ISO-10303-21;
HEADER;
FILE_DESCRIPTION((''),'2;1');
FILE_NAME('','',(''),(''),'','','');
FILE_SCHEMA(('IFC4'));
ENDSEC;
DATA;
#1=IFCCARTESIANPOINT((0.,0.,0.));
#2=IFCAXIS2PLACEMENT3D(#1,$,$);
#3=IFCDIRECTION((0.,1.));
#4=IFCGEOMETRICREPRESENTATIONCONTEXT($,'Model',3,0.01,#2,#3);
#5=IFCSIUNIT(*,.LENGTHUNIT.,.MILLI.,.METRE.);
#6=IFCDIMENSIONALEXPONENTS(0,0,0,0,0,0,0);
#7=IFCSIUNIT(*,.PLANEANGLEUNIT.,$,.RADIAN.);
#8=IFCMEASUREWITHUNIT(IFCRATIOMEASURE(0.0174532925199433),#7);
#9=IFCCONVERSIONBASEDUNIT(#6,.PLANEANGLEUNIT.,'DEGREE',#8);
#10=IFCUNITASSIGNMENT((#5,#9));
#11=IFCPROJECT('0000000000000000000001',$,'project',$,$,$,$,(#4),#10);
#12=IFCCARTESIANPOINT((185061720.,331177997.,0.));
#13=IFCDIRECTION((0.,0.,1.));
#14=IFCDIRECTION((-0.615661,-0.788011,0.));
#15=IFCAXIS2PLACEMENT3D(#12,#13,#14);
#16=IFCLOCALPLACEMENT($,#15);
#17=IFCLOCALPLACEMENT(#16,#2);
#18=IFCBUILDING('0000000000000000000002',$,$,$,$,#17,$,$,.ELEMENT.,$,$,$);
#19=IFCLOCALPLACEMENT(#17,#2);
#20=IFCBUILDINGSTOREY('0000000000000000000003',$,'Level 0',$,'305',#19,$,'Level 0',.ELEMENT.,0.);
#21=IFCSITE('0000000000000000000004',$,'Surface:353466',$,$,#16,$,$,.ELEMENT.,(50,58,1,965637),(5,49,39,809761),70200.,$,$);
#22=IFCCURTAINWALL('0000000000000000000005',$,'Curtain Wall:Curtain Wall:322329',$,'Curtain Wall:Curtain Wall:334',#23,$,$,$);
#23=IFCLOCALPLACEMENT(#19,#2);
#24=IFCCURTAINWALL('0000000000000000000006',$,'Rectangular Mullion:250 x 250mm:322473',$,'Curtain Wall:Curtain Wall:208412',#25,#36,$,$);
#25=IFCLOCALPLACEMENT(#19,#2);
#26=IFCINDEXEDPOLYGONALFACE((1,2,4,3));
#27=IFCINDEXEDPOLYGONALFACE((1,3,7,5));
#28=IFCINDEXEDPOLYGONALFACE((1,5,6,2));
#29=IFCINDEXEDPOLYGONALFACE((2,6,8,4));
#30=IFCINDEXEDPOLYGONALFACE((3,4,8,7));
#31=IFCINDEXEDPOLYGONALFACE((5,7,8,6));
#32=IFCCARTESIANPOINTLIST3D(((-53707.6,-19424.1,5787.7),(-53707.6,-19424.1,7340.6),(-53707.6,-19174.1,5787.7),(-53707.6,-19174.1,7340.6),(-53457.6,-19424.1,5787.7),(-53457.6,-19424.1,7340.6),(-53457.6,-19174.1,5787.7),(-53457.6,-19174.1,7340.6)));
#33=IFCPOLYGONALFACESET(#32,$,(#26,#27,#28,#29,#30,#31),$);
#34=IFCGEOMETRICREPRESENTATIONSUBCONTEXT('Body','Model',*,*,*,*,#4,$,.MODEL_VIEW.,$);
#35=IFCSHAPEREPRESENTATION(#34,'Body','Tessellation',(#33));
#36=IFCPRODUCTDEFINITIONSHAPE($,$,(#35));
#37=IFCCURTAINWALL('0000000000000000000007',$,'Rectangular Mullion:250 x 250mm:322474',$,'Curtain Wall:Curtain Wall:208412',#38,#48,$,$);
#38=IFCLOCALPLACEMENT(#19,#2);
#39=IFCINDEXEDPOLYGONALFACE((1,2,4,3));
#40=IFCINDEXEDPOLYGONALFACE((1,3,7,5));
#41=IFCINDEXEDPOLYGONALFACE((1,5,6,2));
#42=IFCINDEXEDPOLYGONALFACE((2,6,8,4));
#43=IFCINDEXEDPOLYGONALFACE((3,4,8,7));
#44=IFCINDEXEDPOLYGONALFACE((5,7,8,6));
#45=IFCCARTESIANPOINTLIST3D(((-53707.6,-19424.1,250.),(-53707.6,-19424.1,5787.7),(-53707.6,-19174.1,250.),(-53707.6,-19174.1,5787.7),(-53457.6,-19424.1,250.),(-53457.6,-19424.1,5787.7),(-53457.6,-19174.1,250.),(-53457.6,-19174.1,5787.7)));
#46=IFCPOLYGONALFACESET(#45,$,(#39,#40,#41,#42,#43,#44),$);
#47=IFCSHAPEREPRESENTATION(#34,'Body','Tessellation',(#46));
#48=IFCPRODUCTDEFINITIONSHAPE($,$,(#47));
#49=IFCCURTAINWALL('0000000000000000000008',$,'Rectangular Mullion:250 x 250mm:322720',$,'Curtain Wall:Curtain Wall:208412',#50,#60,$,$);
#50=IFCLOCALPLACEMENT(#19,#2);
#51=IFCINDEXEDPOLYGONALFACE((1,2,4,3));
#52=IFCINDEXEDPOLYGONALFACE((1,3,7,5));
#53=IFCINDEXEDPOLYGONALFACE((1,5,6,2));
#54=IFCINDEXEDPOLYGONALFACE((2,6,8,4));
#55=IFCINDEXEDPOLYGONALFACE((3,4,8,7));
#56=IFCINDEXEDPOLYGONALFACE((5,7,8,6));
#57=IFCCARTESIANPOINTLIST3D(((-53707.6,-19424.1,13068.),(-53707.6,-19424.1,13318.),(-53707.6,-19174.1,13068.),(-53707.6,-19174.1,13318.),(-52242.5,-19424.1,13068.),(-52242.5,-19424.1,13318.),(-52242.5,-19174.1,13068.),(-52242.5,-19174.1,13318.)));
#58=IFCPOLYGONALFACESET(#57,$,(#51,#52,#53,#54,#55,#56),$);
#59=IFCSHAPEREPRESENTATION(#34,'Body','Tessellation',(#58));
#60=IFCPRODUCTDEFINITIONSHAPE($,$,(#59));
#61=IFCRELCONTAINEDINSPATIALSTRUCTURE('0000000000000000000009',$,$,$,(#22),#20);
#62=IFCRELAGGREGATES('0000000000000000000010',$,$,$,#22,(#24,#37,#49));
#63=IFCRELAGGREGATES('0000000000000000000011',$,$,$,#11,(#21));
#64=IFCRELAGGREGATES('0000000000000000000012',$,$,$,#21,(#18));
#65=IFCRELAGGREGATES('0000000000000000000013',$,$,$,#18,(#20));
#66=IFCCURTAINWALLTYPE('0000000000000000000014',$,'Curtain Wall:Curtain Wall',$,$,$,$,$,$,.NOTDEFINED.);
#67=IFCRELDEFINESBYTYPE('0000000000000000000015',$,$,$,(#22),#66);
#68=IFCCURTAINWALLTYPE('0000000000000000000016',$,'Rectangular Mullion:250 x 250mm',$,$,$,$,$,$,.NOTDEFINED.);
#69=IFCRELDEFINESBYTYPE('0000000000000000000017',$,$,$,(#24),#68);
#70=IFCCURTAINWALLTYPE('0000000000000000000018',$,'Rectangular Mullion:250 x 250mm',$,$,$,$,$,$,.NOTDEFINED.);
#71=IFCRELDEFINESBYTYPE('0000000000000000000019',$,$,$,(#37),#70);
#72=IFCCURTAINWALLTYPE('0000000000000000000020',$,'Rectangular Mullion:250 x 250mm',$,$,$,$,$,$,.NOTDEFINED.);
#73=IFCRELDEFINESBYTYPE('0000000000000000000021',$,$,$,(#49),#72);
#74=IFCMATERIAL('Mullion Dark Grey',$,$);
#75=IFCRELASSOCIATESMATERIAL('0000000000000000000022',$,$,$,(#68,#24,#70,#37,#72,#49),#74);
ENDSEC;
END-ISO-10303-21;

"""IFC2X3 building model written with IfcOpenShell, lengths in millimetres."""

from ifc_helpers import new_model, entity, si_unit, converted_unit, direction, frame, origin, origin_2d_with_axis, place, context, subcontext, project, spatial, rectangle, extrude, source, transform, mapped, material, type_object, type_shapes, element, aggregate, save


model = new_model("IFC2X3")

# Units and contexts
model_context = context("Model", 3, precision=0.01, world=origin(), true_north=direction((0.0, 1.0)))
body_context = subcontext(model_context, "Body", "Model", "MODEL_VIEW")
ifc_project = project(units=[si_unit("LENGTHUNIT", "METRE", prefix="MILLI"), converted_unit("PLANEANGLEUNIT", "DEGREE", entity("IfcRatioMeasure", 0.0174532925199433), si_unit("PLANEANGLEUNIT", "RADIAN"), dimensions=[0, 0, 0, 0, 0, 0, 0])], contexts=[model_context])

# Site, building, storey
site_placement = place(None, frame((185061720.0, 331177997.0, 0.0), z_axis=(0.0, 0.0, 1.0), x_axis=(-0.615661, -0.788011, 0.0)))
site = spatial("IfcSite", under=ifc_project, at=site_placement, Name="Surface:353466", CompositionType="ELEMENT", RefLatitude=(50, 58, 1, 965637), RefLongitude=(5, 49, 39, 809761), RefElevation=70200.0)
building_placement = place(site_placement, origin())
building = spatial("IfcBuilding", under=site, at=building_placement, CompositionType="ELEMENT")
storey_placement = place(building_placement, origin())
storey = spatial("IfcBuildingStorey", under=building, at=storey_placement, Name="Level 0", ObjectType="305", LongName="Level 0", CompositionType="ELEMENT", Elevation=0.0)

# Curtain walls
curtain_wall_type_1 = type_object("IfcCurtainWallType", Name="Curtain Wall:Curtain Wall", PredefinedType="NOTDEFINED")
curtain_wall_1_placement = place(storey_placement, origin())
curtain_wall_1 = element("IfcCurtainWall", 1, at=curtain_wall_1_placement, inside=storey, type_object=curtain_wall_type_1, Name="Curtain Wall:Curtain Wall:322329", ObjectType="Curtain Wall:Curtain Wall:334")
ifc_material_1 = material(Name="Mullion Dark Grey")
curtain_wall_type_2 = type_object("IfcCurtainWallType", Name="Rectangular Mullion:250 x 250mm", PredefinedType="NOTDEFINED", material=ifc_material_1)
shared_shape_1 = source(origin(), body_context, "Body", "SweptSolid", [
    extrude(rectangle(XDim=250.0, YDim=250.0, at=origin_2d_with_axis()), frame((-125.0, 0.0, -1552.9), z_axis=(0.0, 0.0, 1.0), x_axis=(-1.0, 0.0, 0.0)), (0.0, 0.0, 1.0), 1552.9),
])
type_shapes(curtain_wall_type_2, [shared_shape_1])
curtain_wall_2_placement = place(storey_placement, frame((-53707.6, -19299.1, 5787.7), z_axis=(0.0, 0.0, -1.0), x_axis=(-1.0, 0.0, 0.0)))
curtain_wall_2 = element("IfcCurtainWall", 2, at=curtain_wall_2_placement, type_object=curtain_wall_type_2, material=ifc_material_1, Name="Rectangular Mullion:250 x 250mm:322473", ObjectType="Curtain Wall:Curtain Wall:208412", context=body_context, shape_type="MappedRepresentation", body=[
    mapped(shared_shape_1, transform((0.0, 0.0, 0.0), scale=1.0)),
])
curtain_wall_type_3 = type_object("IfcCurtainWallType", Name="Rectangular Mullion:250 x 250mm", PredefinedType="NOTDEFINED", material=ifc_material_1)
shared_shape_2 = source(origin(), body_context, "Body", "SweptSolid", [
    extrude(rectangle(XDim=250.0, YDim=250.0, at=origin_2d_with_axis()), frame((-125.0, 0.0, -5537.7), z_axis=(0.0, 0.0, 1.0), x_axis=(-1.0, 0.0, 0.0)), (0.0, 0.0, 1.0), 5537.7),
])
type_shapes(curtain_wall_type_3, [shared_shape_2])
curtain_wall_3_placement = place(storey_placement, frame((-53707.6, -19299.1, 250.0), z_axis=(0.0, 0.0, -1.0), x_axis=(-1.0, 0.0, 0.0)))
curtain_wall_3 = element("IfcCurtainWall", 3, at=curtain_wall_3_placement, type_object=curtain_wall_type_3, material=ifc_material_1, Name="Rectangular Mullion:250 x 250mm:322474", ObjectType="Curtain Wall:Curtain Wall:208412", context=body_context, shape_type="MappedRepresentation", body=[
    mapped(shared_shape_2, transform((0.0, 0.0, 0.0), scale=1.0)),
])
curtain_wall_type_4 = type_object("IfcCurtainWallType", Name="Rectangular Mullion:250 x 250mm", PredefinedType="NOTDEFINED", material=ifc_material_1)
shared_shape_3 = source(origin(), body_context, "Body", "SweptSolid", [
    extrude(rectangle(XDim=250.0, YDim=250.0, at=origin_2d_with_axis()), frame((-125.0, 0.0, -1465.0), z_axis=(0.0, 0.0, 1.0), x_axis=(-1.0, 0.0, 0.0)), (0.0, 0.0, 1.0), 1465.0),
])
type_shapes(curtain_wall_type_4, [shared_shape_3])
curtain_wall_4_placement = place(storey_placement, frame((-53707.6, -19299.1, 13318.0), z_axis=(-1.0, 0.0, 0.0), x_axis=(0.0, 0.0, 1.0)))
curtain_wall_4 = element("IfcCurtainWall", 4, at=curtain_wall_4_placement, type_object=curtain_wall_type_4, material=ifc_material_1, Name="Rectangular Mullion:250 x 250mm:322720", ObjectType="Curtain Wall:Curtain Wall:208412", context=body_context, shape_type="MappedRepresentation", body=[
    mapped(shared_shape_3, transform((0.0, 0.0, 0.0), scale=1.0)),
])
aggregate(curtain_wall_1, [curtain_wall_2, curtain_wall_3, curtain_wall_4])

save(model, "model.ifc")
